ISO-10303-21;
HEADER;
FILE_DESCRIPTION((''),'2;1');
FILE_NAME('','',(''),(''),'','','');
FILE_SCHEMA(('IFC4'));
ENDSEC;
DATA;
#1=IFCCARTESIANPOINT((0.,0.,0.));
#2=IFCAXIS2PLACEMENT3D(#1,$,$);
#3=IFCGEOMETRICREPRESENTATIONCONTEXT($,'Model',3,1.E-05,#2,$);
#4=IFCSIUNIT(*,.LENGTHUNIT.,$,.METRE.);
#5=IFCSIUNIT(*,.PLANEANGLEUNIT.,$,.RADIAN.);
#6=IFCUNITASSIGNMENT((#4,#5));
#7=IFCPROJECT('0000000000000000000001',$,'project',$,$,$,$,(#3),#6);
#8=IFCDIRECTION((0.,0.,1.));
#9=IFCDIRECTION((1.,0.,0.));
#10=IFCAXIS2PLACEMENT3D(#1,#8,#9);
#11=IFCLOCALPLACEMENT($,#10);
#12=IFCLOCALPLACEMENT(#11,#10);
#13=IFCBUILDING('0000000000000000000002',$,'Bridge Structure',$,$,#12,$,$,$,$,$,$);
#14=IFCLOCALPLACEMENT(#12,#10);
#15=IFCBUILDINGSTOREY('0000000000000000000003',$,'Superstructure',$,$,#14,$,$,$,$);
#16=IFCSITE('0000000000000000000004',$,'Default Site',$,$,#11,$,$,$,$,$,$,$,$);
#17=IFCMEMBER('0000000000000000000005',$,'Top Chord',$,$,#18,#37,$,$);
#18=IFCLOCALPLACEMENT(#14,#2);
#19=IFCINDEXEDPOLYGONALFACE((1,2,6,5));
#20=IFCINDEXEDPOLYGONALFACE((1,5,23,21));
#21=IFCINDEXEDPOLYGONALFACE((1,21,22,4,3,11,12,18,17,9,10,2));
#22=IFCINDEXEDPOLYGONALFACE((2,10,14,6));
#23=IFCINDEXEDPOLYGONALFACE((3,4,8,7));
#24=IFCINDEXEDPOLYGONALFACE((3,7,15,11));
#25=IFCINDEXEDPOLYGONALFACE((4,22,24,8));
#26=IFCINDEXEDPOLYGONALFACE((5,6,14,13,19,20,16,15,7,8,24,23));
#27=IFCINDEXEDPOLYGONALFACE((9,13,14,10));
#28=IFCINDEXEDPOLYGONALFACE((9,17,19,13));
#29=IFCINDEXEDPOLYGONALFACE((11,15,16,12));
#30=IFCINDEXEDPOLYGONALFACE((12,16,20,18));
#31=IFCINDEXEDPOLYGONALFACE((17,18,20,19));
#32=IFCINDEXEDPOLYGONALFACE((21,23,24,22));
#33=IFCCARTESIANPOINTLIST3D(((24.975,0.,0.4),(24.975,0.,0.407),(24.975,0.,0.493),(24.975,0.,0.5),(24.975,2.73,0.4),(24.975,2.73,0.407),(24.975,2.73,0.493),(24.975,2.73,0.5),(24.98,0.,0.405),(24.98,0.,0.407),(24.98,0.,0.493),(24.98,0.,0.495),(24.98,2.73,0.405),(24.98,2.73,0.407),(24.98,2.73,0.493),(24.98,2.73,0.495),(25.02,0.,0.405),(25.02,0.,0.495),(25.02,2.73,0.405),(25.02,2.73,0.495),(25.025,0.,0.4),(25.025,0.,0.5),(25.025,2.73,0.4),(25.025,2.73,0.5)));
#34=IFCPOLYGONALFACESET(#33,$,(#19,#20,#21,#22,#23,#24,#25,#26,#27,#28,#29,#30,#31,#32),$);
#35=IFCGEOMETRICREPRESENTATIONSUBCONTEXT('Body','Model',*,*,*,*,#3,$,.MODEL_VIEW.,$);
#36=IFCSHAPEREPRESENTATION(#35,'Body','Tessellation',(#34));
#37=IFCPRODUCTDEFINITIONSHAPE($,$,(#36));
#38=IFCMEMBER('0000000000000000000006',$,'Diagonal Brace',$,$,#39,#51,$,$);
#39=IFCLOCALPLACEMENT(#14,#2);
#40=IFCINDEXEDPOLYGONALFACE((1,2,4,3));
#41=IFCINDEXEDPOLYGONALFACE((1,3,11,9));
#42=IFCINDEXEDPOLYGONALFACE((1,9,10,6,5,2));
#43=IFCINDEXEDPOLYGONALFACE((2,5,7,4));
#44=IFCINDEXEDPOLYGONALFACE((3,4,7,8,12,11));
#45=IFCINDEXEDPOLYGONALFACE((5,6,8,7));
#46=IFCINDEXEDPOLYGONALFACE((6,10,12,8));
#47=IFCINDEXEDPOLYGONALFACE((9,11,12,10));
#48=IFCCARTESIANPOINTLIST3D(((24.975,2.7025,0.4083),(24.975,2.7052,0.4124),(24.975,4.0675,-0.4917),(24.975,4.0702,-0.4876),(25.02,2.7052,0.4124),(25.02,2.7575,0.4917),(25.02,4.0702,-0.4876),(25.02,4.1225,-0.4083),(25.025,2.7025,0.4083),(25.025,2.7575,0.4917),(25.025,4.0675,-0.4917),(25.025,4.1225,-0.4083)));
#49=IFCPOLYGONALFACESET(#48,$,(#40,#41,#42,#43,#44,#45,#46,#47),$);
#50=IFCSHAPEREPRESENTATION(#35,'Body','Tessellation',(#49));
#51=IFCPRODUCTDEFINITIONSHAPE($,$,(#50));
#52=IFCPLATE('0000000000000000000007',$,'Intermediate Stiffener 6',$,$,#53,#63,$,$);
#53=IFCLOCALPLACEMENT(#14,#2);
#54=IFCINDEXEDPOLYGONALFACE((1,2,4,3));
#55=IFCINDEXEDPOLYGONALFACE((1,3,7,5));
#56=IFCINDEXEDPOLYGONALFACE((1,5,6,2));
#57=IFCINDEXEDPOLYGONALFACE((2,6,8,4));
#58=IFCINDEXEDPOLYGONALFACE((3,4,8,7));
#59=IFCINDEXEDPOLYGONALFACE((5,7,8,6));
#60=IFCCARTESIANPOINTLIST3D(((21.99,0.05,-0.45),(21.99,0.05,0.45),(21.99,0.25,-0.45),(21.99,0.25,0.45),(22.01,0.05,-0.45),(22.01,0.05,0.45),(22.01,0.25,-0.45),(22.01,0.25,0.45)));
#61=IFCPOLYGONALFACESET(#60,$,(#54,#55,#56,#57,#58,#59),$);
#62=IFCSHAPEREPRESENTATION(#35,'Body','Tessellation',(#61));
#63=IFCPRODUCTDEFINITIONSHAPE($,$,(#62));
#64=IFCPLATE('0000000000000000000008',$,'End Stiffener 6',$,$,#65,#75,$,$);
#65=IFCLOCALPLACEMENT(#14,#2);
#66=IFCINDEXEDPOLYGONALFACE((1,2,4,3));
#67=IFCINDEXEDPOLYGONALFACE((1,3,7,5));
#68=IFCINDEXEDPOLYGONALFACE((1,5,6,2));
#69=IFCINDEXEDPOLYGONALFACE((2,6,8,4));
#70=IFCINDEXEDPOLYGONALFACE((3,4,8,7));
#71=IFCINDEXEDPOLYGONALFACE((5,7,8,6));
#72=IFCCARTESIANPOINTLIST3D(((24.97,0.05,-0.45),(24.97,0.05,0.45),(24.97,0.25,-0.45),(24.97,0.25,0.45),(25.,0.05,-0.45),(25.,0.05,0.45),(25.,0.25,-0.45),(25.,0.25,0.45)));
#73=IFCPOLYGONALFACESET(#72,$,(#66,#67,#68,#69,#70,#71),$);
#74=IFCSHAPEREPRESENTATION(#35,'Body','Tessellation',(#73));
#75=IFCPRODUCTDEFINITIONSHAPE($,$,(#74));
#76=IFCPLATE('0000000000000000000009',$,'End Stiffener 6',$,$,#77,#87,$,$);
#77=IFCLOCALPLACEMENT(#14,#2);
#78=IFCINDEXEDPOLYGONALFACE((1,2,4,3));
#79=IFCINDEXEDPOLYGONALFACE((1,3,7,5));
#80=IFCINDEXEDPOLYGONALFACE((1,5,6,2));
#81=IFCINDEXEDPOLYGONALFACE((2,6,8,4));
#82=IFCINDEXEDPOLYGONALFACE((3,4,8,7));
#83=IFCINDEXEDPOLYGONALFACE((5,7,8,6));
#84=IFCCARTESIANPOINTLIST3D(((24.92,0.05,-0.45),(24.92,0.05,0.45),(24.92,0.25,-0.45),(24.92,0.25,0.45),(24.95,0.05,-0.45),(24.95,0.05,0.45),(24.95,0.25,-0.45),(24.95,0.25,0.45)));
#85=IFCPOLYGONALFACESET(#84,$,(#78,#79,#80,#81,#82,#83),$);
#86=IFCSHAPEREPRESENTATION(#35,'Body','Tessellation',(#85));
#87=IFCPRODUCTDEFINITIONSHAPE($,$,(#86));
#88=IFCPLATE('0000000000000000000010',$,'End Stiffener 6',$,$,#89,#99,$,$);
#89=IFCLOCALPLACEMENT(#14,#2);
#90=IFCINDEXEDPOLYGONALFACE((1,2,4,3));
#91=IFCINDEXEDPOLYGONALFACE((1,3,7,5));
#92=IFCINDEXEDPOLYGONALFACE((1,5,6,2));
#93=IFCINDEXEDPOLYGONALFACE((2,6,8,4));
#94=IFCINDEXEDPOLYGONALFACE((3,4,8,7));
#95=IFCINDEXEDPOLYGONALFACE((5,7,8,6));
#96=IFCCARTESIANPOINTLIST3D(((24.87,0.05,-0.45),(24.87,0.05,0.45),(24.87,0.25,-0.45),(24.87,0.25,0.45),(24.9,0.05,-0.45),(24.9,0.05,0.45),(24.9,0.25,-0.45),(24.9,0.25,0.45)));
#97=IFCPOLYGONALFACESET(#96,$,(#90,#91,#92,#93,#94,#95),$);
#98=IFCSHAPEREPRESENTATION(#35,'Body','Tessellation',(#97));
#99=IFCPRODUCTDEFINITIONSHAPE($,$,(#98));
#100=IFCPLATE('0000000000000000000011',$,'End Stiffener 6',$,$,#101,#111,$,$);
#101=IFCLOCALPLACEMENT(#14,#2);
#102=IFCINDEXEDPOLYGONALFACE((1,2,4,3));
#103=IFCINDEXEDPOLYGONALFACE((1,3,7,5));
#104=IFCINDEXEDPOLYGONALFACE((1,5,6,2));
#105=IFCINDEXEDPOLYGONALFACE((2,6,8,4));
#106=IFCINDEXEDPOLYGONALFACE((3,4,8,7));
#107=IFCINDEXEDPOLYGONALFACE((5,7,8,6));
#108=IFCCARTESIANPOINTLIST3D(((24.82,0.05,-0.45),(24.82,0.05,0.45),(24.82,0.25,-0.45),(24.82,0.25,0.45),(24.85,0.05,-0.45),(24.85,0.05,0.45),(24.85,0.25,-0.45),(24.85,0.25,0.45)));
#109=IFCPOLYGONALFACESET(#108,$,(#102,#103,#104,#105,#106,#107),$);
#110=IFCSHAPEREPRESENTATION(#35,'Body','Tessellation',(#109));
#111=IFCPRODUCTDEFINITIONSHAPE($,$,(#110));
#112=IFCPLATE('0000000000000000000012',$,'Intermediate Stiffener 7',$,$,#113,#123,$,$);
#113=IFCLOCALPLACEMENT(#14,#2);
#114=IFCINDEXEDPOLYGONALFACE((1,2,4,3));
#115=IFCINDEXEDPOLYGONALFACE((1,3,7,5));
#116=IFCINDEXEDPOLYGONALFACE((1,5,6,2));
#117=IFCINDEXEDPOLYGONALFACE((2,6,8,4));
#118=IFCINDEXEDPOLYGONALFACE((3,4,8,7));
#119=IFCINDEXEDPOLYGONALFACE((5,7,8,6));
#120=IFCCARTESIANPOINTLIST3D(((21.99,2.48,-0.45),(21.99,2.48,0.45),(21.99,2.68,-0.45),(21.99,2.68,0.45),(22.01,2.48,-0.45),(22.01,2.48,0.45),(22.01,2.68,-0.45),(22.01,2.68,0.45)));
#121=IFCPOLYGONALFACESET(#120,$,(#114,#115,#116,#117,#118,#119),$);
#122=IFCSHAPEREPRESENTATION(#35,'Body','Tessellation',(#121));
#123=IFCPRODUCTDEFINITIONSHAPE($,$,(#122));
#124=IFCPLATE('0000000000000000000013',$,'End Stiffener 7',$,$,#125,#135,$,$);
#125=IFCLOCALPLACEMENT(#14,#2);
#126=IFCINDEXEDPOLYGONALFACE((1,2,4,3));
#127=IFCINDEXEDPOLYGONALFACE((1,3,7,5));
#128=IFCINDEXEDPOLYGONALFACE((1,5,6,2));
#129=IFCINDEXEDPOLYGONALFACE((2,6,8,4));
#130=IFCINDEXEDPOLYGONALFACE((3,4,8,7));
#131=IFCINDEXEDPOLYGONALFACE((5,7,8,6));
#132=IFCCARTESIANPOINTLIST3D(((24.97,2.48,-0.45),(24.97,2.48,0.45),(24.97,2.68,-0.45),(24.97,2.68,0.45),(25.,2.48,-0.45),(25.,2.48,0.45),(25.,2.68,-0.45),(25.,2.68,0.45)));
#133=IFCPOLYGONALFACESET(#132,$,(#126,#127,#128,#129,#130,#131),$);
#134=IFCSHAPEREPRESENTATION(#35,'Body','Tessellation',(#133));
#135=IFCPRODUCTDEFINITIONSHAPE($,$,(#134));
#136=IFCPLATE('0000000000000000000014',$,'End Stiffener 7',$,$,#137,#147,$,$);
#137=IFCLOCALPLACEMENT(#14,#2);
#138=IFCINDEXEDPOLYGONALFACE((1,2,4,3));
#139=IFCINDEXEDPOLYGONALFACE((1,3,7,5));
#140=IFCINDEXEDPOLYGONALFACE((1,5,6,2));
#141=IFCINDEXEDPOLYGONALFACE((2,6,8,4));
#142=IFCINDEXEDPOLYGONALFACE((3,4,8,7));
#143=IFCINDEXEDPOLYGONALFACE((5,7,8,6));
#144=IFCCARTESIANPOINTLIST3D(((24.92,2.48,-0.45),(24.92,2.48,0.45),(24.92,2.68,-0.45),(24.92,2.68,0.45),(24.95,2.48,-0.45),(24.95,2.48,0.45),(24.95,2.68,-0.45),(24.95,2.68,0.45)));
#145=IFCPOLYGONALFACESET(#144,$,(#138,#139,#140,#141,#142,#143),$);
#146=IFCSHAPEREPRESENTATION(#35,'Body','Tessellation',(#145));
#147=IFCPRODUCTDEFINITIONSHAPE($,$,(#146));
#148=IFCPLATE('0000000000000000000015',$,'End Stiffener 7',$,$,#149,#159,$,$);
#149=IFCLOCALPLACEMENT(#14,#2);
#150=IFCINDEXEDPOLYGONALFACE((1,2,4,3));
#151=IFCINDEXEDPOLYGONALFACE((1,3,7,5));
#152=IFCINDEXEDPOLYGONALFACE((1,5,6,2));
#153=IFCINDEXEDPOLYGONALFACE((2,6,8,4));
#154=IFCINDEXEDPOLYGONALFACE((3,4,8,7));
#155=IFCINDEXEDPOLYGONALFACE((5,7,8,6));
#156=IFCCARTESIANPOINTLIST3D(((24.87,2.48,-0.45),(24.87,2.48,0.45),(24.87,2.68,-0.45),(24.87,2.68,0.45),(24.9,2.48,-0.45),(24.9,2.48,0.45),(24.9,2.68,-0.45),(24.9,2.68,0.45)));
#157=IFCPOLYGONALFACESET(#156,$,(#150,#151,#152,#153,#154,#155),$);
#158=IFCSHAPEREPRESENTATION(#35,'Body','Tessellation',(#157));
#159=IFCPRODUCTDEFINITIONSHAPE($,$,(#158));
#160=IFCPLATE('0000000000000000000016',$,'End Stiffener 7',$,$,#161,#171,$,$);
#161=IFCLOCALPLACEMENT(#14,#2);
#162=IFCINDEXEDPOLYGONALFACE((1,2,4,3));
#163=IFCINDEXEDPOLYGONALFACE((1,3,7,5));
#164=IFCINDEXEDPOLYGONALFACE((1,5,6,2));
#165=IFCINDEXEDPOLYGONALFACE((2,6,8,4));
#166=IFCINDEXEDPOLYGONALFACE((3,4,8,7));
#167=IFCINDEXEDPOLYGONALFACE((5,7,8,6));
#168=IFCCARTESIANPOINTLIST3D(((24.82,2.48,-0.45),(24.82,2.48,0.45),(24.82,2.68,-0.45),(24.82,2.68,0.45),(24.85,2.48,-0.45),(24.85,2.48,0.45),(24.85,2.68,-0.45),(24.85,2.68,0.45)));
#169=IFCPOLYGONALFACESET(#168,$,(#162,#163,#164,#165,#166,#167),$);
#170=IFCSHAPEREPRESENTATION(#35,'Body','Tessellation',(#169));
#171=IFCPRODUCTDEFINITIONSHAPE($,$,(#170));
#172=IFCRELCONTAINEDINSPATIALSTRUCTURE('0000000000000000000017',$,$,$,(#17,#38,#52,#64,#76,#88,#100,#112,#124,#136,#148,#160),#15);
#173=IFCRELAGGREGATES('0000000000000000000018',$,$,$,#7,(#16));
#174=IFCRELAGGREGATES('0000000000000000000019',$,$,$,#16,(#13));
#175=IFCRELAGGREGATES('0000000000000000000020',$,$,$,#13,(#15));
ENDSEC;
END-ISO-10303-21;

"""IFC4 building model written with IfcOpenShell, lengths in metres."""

from ifc_helpers import new_model, si_unit, frame, origin, origin_with_axes, origin_2d_with_axis, place, context, subcontext, project, spatial, rectangle, l_section, c_section, extrude, element, save


model = new_model("IFC4")

# Units and contexts
model_context = context("Model", 3, precision=1e-05, world=origin())
body_context = subcontext(model_context, "Body", "Model", "MODEL_VIEW")
ifc_project = project(units=[si_unit("LENGTHUNIT", "METRE"), si_unit("PLANEANGLEUNIT", "RADIAN")], contexts=[model_context])

# Site, building, storey
site_placement = place(None, origin_with_axes())
site = spatial("IfcSite", under=ifc_project, at=site_placement, Name="Default Site")
building_placement = place(site_placement, origin_with_axes())
building = spatial("IfcBuilding", under=site, at=building_placement, Name="Bridge Structure")
storey_placement = place(building_placement, origin_with_axes())
storey = spatial("IfcBuildingStorey", under=building, at=storey_placement, Name="Superstructure")

# Members
member_1_placement = place(storey_placement, frame((25.0, 0.0, 0.45), z_axis=(0.0, 1.0, 0.0), x_axis=(-1.0, 0.0, 0.0)))
element("IfcMember", 1, at=member_1_placement, inside=storey, Name="Top Chord", context=body_context, shape_type="SweptSolid", body=[
    extrude(c_section(Depth=0.1, Width=0.05, WallThickness=0.005, Girth=0.007, at=origin_2d_with_axis()), origin_with_axes(), (0.0, 0.0, 1.0), 2.73),
])
member_2_placement = place(storey_placement, frame((25.0, 2.73, 0.45), z_axis=(0.0, 0.834862, -0.550459), x_axis=(-1.0, 0.0, 0.0)))
element("IfcMember", 2, at=member_2_placement, inside=storey, Name="Diagonal Brace", context=body_context, shape_type="SweptSolid", body=[
    extrude(l_section(Depth=0.1, Width=0.05, Thickness=0.005, at=origin_2d_with_axis()), origin_with_axes(), (0.0, 0.0, 1.0), 1.635),
])

# Plates
plate_1_placement = place(storey_placement, frame((22.0, 0.15, -0.45), z_axis=(0.0, 0.0, 1.0), x_axis=(1.0, 0.0, 0.0)))
element("IfcPlate", 3, at=plate_1_placement, inside=storey, Name="Intermediate Stiffener 6", context=body_context, shape_type="SweptSolid", body=[
    extrude(rectangle(XDim=0.02, YDim=0.2, at=origin_2d_with_axis()), origin_with_axes(), (0.0, 0.0, 1.0), 0.9),
])
for number, where, z_axis, x_axis, name in (
    (4, (24.985, 0.15, -0.45), (0.0, 0.0, 1.0), (1.0, 0.0, 0.0), "End Stiffener 6"),
    (5, (24.935, 0.15, -0.45), (0.0, 0.0, 1.0), (1.0, 0.0, 0.0), "End Stiffener 6"),
    (6, (24.885, 0.15, -0.45), (0.0, 0.0, 1.0), (1.0, 0.0, 0.0), "End Stiffener 6"),
    (7, (24.835, 0.15, -0.45), (0.0, 0.0, 1.0), (1.0, 0.0, 0.0), "End Stiffener 6"),
):
    element("IfcPlate", number, at=place(storey_placement, frame(where, z_axis=z_axis, x_axis=x_axis)), inside=storey, Name=name, context=body_context, shape_type="SweptSolid", body=[
        extrude(rectangle(XDim=0.03, YDim=0.2, at=origin_2d_with_axis()), origin_with_axes(), (0.0, 0.0, 1.0), 0.9),
    ])
plate_2_placement = place(storey_placement, frame((22.0, 2.58, -0.45), z_axis=(0.0, 0.0, 1.0), x_axis=(1.0, 0.0, 0.0)))
element("IfcPlate", 8, at=plate_2_placement, inside=storey, Name="Intermediate Stiffener 7", context=body_context, shape_type="SweptSolid", body=[
    extrude(rectangle(XDim=0.02, YDim=0.2, at=origin_2d_with_axis()), origin_with_axes(), (0.0, 0.0, 1.0), 0.9),
])
for number, where, z_axis, x_axis, name in (
    (9, (24.985, 2.58, -0.45), (0.0, 0.0, 1.0), (1.0, 0.0, 0.0), "End Stiffener 7"),
    (10, (24.935, 2.58, -0.45), (0.0, 0.0, 1.0), (1.0, 0.0, 0.0), "End Stiffener 7"),
    (11, (24.885, 2.58, -0.45), (0.0, 0.0, 1.0), (1.0, 0.0, 0.0), "End Stiffener 7"),
    (12, (24.835, 2.58, -0.45), (0.0, 0.0, 1.0), (1.0, 0.0, 0.0), "End Stiffener 7"),
):
    element("IfcPlate", number, at=place(storey_placement, frame(where, z_axis=z_axis, x_axis=x_axis)), inside=storey, Name=name, context=body_context, shape_type="SweptSolid", body=[
        extrude(rectangle(XDim=0.03, YDim=0.2, at=origin_2d_with_axis()), origin_with_axes(), (0.0, 0.0, 1.0), 0.9),
    ])

save(model, "model.ifc")
